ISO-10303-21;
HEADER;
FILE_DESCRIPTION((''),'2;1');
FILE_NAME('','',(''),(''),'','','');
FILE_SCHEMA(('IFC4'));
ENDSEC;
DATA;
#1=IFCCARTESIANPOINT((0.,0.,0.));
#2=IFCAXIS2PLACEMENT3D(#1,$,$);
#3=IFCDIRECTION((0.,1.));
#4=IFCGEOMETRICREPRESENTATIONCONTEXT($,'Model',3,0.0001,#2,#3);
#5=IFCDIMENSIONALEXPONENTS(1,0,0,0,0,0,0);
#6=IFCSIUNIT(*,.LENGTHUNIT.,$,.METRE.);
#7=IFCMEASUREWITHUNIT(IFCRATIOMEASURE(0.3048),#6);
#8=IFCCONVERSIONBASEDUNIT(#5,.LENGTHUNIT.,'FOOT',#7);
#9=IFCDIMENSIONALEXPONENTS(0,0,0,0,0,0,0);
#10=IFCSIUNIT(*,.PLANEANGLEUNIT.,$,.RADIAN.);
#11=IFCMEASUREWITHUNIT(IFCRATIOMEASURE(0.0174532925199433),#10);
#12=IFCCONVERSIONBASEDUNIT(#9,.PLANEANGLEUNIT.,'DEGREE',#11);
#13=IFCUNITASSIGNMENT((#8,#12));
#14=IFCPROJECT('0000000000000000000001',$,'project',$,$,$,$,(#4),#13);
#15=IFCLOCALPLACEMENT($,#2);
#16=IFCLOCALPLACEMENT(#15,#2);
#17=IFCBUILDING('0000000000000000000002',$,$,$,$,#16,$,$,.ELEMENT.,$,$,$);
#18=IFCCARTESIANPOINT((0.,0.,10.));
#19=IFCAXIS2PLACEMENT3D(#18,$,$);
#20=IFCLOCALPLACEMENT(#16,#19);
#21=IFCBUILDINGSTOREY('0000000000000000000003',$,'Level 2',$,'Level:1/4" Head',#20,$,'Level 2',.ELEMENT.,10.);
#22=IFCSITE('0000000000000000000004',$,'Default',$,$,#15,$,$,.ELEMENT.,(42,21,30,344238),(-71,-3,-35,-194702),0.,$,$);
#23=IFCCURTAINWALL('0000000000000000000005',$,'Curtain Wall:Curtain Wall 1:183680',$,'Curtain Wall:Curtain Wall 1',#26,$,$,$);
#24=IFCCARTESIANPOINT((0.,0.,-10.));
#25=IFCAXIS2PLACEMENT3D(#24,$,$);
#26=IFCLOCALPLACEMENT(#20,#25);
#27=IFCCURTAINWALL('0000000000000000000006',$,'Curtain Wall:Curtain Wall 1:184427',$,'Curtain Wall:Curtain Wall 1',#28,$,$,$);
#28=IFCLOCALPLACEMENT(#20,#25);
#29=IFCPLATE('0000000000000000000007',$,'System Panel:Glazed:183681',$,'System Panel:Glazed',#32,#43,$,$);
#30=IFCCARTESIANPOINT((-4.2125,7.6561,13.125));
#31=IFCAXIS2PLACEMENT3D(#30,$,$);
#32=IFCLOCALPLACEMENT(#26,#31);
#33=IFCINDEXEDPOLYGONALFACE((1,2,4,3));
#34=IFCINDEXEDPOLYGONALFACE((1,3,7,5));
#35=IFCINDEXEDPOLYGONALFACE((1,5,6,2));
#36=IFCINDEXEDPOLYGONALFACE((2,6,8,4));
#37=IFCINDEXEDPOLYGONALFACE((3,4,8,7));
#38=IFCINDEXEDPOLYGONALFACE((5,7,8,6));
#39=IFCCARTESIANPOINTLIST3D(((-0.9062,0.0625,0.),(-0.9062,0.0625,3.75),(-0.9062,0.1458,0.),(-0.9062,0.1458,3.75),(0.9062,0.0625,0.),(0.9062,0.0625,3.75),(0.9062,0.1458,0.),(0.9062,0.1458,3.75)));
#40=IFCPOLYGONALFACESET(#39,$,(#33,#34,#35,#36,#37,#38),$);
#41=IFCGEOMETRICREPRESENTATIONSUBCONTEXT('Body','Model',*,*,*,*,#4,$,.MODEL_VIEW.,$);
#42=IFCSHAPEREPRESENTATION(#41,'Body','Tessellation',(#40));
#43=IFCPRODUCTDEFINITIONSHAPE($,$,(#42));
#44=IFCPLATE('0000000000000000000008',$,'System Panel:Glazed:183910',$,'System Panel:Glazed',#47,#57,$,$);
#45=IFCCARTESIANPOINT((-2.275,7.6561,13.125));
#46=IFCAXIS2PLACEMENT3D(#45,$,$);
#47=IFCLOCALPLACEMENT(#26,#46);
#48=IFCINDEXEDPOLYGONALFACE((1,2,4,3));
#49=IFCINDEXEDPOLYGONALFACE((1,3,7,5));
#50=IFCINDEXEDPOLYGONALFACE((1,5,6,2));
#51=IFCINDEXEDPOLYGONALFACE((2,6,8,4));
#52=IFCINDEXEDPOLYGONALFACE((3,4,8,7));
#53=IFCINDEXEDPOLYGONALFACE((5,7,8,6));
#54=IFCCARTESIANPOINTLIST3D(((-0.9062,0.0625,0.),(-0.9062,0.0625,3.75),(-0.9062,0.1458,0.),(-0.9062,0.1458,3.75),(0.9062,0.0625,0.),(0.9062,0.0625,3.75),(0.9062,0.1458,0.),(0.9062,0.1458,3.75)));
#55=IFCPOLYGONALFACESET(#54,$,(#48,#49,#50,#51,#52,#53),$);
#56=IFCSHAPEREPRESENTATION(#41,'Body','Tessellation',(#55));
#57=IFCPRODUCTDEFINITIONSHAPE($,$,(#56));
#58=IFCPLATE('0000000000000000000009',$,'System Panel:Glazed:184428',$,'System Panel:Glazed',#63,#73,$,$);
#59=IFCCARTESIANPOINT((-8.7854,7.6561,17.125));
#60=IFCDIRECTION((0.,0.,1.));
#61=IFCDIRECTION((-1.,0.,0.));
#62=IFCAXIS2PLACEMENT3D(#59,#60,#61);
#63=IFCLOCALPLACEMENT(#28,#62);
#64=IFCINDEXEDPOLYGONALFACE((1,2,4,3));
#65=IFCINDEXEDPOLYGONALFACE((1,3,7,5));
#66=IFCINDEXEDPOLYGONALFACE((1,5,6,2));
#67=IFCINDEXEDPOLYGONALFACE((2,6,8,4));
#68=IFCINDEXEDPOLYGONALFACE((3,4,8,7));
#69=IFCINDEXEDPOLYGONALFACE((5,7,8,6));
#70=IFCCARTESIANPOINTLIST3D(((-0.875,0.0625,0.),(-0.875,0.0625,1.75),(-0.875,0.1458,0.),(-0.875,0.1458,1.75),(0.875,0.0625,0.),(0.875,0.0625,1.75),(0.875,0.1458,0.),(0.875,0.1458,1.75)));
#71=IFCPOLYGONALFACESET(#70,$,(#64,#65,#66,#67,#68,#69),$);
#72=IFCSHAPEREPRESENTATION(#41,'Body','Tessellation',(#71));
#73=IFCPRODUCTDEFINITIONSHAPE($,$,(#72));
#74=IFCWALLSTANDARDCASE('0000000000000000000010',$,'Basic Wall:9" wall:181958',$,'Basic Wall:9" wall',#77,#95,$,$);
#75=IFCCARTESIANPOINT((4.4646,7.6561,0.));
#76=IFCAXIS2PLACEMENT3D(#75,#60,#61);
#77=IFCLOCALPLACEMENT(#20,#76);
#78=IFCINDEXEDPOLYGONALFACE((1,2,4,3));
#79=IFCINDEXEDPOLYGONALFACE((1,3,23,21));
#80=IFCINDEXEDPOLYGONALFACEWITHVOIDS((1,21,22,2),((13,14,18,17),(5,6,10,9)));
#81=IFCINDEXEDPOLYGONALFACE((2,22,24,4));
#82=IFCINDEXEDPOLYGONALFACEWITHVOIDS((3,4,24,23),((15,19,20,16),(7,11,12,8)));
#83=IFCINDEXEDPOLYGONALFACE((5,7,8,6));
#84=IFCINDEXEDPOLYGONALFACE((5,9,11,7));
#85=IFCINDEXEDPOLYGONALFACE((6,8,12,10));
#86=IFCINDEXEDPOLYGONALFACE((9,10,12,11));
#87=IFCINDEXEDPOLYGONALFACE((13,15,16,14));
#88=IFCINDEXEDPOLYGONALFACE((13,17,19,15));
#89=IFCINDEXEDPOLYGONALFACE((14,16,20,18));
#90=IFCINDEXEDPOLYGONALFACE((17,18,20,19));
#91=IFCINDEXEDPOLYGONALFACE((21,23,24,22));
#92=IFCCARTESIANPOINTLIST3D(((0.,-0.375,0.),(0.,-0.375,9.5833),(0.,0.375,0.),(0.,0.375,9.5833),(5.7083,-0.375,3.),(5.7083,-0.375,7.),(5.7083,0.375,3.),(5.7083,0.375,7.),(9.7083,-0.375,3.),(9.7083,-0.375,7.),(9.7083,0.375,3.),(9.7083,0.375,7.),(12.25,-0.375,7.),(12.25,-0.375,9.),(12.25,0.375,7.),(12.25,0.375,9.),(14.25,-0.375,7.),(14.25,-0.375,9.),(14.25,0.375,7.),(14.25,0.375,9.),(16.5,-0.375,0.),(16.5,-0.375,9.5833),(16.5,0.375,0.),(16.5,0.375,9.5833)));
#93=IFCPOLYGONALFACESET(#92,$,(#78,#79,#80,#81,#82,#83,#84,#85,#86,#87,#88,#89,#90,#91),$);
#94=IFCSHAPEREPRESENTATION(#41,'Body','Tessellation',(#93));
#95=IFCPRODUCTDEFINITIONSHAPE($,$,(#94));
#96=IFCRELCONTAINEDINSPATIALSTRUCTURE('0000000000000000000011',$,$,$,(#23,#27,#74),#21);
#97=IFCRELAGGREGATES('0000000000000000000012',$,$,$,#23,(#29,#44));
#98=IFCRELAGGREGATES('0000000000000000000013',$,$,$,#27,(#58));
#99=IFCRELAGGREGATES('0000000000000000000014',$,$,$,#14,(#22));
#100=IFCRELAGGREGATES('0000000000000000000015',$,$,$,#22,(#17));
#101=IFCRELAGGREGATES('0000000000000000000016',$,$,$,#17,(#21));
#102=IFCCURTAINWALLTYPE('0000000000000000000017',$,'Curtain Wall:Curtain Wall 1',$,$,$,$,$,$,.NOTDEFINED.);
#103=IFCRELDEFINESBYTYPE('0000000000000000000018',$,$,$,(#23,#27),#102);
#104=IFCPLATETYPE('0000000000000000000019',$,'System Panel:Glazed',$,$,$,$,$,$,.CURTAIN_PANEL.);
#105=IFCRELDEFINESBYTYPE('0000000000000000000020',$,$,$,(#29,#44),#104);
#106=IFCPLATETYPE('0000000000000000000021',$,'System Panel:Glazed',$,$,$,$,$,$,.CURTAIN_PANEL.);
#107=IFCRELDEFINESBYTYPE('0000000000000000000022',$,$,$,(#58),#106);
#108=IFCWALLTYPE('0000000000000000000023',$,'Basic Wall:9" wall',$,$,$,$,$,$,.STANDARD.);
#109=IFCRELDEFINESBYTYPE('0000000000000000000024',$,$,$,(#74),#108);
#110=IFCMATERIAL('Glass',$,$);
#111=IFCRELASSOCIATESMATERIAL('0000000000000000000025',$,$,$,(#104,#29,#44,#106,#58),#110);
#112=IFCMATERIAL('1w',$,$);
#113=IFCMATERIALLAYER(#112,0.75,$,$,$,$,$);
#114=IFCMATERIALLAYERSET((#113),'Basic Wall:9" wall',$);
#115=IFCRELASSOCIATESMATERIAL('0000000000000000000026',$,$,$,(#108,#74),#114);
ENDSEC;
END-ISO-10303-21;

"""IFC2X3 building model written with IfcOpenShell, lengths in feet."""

from ifc_helpers import new_model, entity, si_unit, converted_unit, direction, frame, frame_2d, origin, place, context, subcontext, project, spatial, polyline, rectangle, extrude, clip, bounded_halfspace, source, transform, mapped, material, layer, layer_set, layer_usage, type_object, type_shapes, element, aggregate, save


model = new_model("IFC2X3")

# Units and contexts
model_context = context("Model", 3, precision=0.0001, world=origin(), true_north=direction((0.0, 1.0)))
body_context = subcontext(model_context, "Body", "Model", "MODEL_VIEW")
ifc_project = project(units=[converted_unit("LENGTHUNIT", "FOOT", entity("IfcRatioMeasure", 0.3048), si_unit("LENGTHUNIT", "METRE"), dimensions=[1, 0, 0, 0, 0, 0, 0]), converted_unit("PLANEANGLEUNIT", "DEGREE", entity("IfcRatioMeasure", 0.0174532925199433), si_unit("PLANEANGLEUNIT", "RADIAN"), dimensions=[0, 0, 0, 0, 0, 0, 0])], contexts=[model_context])

# Site, building, storey
site_placement = place(None, origin())
site = spatial("IfcSite", under=ifc_project, at=site_placement, Name="Default", CompositionType="ELEMENT", RefLatitude=(42, 21, 30, 344238), RefLongitude=(-71, -3, -35, -194702), RefElevation=0.0)
building_placement = place(site_placement, origin())
building = spatial("IfcBuilding", under=site, at=building_placement, CompositionType="ELEMENT")
storey_placement = place(building_placement, frame((0.0, 0.0, 10.0)))
storey = spatial("IfcBuildingStorey", under=building, at=storey_placement, Name="Level 2", ObjectType="Level:1/4\" Head", LongName="Level 2", CompositionType="ELEMENT", Elevation=10.0)

# Curtain walls
curtain_wall_type = type_object("IfcCurtainWallType", Name="Curtain Wall:Curtain Wall 1", PredefinedType="NOTDEFINED")
curtain_wall_1_placement = place(storey_placement, frame((0.0, 0.0, -10.0)))
curtain_wall_1 = element("IfcCurtainWall", 1, at=curtain_wall_1_placement, inside=storey, type_object=curtain_wall_type, Name="Curtain Wall:Curtain Wall 1:183680", ObjectType="Curtain Wall:Curtain Wall 1")
curtain_wall_2_placement = place(storey_placement, frame((0.0, 0.0, -10.0)))
curtain_wall_2 = element("IfcCurtainWall", 2, at=curtain_wall_2_placement, inside=storey, type_object=curtain_wall_type, Name="Curtain Wall:Curtain Wall 1:184427", ObjectType="Curtain Wall:Curtain Wall 1")

# Shared definitions
ifc_material_1 = material(Name="1w")

# Plates
ifc_material_2 = material(Name="Glass")
plate_type_1 = type_object("IfcPlateType", Name="System Panel:Glazed", PredefinedType="CURTAIN_PANEL", material=ifc_material_2)
shared_shape_1 = source(origin(), body_context, "Body", "SweptSolid", [
    extrude(rectangle(XDim=0.0833, YDim=1.8125, at=frame_2d((0.0, 0.0), x_axis=(1.0, 0.0))), frame((0.0, 0.1042, 0.0), z_axis=(0.0, 0.0, 1.0), x_axis=(0.0, 1.0, 0.0)), (0.0, 0.0, 1.0), 3.75),
])
type_shapes(plate_type_1, [shared_shape_1])
plate_1_placement = place(curtain_wall_1_placement, frame((-4.2125, 7.6561, 13.125)))
plate_1 = element("IfcPlate", 3, at=plate_1_placement, type_object=plate_type_1, material=ifc_material_2, Name="System Panel:Glazed:183681", ObjectType="System Panel:Glazed", context=body_context, shape_type="MappedRepresentation", body=[
    mapped(shared_shape_1, transform((0.0, 0.0, 0.0), scale=1.0)),
])
plate_2_placement = place(curtain_wall_1_placement, frame((-2.275, 7.6561, 13.125)))
plate_2 = element("IfcPlate", 4, at=plate_2_placement, type_object=plate_type_1, material=ifc_material_2, Name="System Panel:Glazed:183910", ObjectType="System Panel:Glazed", context=body_context, shape_type="MappedRepresentation", body=[
    mapped(shared_shape_1, transform((0.0, 0.0, 0.0), scale=1.0)),
])
aggregate(curtain_wall_1, [plate_1, plate_2])
plate_type_2 = type_object("IfcPlateType", Name="System Panel:Glazed", PredefinedType="CURTAIN_PANEL", material=ifc_material_2)
shared_shape_2 = source(origin(), body_context, "Body", "SweptSolid", [
    extrude(rectangle(XDim=0.0833, YDim=1.75, at=frame_2d((0.0, 0.0), x_axis=(1.0, 0.0))), frame((0.0, 0.1042, 0.0), z_axis=(0.0, 0.0, 1.0), x_axis=(0.0, 1.0, 0.0)), (0.0, 0.0, 1.0), 1.75),
])
type_shapes(plate_type_2, [shared_shape_2])
plate_3_placement = place(curtain_wall_2_placement, frame((-8.7854, 7.6561, 17.125), z_axis=(0.0, 0.0, 1.0), x_axis=(-1.0, 0.0, 0.0)))
plate_3 = element("IfcPlate", 5, at=plate_3_placement, type_object=plate_type_2, material=ifc_material_2, Name="System Panel:Glazed:184428", ObjectType="System Panel:Glazed", context=body_context, shape_type="MappedRepresentation", body=[
    mapped(shared_shape_2, transform((0.0, 0.0, 0.0), scale=1.0)),
])
aggregate(curtain_wall_2, [plate_3])

# Shared definitions
ifc_layer_1 = layer(ifc_material_1, 0.75)
ifc_layer_set_1 = layer_set([ifc_layer_1], Name="Basic Wall:9\" wall")
wall_type = type_object("IfcWallType", Name="Basic Wall:9\" wall", PredefinedType="STANDARD", material=ifc_layer_set_1)

# Wall, openings
ifc_layer_usage_1 = layer_usage(ifc_layer_set_1, "AXIS2", "POSITIVE", -0.375)
wall_1_placement = place(storey_placement, frame((4.4646, 7.6561, 0.0), z_axis=(0.0, 0.0, 1.0), x_axis=(-1.0, 0.0, 0.0)))
wall_1 = element("IfcWallStandardCase", 6, at=wall_1_placement, inside=storey, type_object=wall_type, material=ifc_layer_usage_1, Name="Basic Wall:9\" wall:181958", ObjectType="Basic Wall:9\" wall", context=body_context, shape_type="Clipping", body=[
    clip(extrude(rectangle(XDim=16.5, YDim=0.75, at=frame_2d((8.25, 0.0), x_axis=(-1.0, 0.0))), origin(), (0.0, 0.0, 1.0), 9.5833), bounded_halfspace(frame((0.0, -0.375, 9.5833), z_axis=(0.0, 0.0, -1.0), x_axis=(0.0, 1.0, 0.0)), True, frame((0.0, -0.375, 9.5833)), polyline([(0.0, 0.0), (10.0, 0.0), (10.75, 0.0), (15.75, 0.0), (16.5, 0.0), (16.5, 0.75), (0.0, 0.75), (0.0, 0.0)]))),
])
opening_1_placement = place(wall_1_placement, origin())
element("IfcOpeningElement", 7, at=opening_1_placement, cuts=wall_1, ObjectType="Opening", context=body_context, shape_type="SweptSolid", body=[
    extrude(rectangle(XDim=4.0, YDim=4.0, at=frame_2d((0.0, 0.0), x_axis=(0.0, 1.0))), frame((7.7083, -0.875, 5.0), z_axis=(0.0, 1.0, 0.0), x_axis=(-1.0, 0.0, 0.0)), (0.0, 0.0, 1.0), 1.75),
])
opening_2_placement = place(wall_1_placement, origin())
element("IfcOpeningElement", 8, at=opening_2_placement, cuts=wall_1, ObjectType="Opening", context=body_context, shape_type="SweptSolid", body=[
    extrude(rectangle(XDim=2.0, YDim=2.0, at=frame_2d((0.0, 0.0), x_axis=(1.0, 0.0))), frame((13.25, -0.875, 8.0), z_axis=(0.0, 1.0, 0.0), x_axis=(0.0, 0.0, 1.0)), (0.0, 0.0, 1.0), 1.75),
])

save(model, "model.ifc")
